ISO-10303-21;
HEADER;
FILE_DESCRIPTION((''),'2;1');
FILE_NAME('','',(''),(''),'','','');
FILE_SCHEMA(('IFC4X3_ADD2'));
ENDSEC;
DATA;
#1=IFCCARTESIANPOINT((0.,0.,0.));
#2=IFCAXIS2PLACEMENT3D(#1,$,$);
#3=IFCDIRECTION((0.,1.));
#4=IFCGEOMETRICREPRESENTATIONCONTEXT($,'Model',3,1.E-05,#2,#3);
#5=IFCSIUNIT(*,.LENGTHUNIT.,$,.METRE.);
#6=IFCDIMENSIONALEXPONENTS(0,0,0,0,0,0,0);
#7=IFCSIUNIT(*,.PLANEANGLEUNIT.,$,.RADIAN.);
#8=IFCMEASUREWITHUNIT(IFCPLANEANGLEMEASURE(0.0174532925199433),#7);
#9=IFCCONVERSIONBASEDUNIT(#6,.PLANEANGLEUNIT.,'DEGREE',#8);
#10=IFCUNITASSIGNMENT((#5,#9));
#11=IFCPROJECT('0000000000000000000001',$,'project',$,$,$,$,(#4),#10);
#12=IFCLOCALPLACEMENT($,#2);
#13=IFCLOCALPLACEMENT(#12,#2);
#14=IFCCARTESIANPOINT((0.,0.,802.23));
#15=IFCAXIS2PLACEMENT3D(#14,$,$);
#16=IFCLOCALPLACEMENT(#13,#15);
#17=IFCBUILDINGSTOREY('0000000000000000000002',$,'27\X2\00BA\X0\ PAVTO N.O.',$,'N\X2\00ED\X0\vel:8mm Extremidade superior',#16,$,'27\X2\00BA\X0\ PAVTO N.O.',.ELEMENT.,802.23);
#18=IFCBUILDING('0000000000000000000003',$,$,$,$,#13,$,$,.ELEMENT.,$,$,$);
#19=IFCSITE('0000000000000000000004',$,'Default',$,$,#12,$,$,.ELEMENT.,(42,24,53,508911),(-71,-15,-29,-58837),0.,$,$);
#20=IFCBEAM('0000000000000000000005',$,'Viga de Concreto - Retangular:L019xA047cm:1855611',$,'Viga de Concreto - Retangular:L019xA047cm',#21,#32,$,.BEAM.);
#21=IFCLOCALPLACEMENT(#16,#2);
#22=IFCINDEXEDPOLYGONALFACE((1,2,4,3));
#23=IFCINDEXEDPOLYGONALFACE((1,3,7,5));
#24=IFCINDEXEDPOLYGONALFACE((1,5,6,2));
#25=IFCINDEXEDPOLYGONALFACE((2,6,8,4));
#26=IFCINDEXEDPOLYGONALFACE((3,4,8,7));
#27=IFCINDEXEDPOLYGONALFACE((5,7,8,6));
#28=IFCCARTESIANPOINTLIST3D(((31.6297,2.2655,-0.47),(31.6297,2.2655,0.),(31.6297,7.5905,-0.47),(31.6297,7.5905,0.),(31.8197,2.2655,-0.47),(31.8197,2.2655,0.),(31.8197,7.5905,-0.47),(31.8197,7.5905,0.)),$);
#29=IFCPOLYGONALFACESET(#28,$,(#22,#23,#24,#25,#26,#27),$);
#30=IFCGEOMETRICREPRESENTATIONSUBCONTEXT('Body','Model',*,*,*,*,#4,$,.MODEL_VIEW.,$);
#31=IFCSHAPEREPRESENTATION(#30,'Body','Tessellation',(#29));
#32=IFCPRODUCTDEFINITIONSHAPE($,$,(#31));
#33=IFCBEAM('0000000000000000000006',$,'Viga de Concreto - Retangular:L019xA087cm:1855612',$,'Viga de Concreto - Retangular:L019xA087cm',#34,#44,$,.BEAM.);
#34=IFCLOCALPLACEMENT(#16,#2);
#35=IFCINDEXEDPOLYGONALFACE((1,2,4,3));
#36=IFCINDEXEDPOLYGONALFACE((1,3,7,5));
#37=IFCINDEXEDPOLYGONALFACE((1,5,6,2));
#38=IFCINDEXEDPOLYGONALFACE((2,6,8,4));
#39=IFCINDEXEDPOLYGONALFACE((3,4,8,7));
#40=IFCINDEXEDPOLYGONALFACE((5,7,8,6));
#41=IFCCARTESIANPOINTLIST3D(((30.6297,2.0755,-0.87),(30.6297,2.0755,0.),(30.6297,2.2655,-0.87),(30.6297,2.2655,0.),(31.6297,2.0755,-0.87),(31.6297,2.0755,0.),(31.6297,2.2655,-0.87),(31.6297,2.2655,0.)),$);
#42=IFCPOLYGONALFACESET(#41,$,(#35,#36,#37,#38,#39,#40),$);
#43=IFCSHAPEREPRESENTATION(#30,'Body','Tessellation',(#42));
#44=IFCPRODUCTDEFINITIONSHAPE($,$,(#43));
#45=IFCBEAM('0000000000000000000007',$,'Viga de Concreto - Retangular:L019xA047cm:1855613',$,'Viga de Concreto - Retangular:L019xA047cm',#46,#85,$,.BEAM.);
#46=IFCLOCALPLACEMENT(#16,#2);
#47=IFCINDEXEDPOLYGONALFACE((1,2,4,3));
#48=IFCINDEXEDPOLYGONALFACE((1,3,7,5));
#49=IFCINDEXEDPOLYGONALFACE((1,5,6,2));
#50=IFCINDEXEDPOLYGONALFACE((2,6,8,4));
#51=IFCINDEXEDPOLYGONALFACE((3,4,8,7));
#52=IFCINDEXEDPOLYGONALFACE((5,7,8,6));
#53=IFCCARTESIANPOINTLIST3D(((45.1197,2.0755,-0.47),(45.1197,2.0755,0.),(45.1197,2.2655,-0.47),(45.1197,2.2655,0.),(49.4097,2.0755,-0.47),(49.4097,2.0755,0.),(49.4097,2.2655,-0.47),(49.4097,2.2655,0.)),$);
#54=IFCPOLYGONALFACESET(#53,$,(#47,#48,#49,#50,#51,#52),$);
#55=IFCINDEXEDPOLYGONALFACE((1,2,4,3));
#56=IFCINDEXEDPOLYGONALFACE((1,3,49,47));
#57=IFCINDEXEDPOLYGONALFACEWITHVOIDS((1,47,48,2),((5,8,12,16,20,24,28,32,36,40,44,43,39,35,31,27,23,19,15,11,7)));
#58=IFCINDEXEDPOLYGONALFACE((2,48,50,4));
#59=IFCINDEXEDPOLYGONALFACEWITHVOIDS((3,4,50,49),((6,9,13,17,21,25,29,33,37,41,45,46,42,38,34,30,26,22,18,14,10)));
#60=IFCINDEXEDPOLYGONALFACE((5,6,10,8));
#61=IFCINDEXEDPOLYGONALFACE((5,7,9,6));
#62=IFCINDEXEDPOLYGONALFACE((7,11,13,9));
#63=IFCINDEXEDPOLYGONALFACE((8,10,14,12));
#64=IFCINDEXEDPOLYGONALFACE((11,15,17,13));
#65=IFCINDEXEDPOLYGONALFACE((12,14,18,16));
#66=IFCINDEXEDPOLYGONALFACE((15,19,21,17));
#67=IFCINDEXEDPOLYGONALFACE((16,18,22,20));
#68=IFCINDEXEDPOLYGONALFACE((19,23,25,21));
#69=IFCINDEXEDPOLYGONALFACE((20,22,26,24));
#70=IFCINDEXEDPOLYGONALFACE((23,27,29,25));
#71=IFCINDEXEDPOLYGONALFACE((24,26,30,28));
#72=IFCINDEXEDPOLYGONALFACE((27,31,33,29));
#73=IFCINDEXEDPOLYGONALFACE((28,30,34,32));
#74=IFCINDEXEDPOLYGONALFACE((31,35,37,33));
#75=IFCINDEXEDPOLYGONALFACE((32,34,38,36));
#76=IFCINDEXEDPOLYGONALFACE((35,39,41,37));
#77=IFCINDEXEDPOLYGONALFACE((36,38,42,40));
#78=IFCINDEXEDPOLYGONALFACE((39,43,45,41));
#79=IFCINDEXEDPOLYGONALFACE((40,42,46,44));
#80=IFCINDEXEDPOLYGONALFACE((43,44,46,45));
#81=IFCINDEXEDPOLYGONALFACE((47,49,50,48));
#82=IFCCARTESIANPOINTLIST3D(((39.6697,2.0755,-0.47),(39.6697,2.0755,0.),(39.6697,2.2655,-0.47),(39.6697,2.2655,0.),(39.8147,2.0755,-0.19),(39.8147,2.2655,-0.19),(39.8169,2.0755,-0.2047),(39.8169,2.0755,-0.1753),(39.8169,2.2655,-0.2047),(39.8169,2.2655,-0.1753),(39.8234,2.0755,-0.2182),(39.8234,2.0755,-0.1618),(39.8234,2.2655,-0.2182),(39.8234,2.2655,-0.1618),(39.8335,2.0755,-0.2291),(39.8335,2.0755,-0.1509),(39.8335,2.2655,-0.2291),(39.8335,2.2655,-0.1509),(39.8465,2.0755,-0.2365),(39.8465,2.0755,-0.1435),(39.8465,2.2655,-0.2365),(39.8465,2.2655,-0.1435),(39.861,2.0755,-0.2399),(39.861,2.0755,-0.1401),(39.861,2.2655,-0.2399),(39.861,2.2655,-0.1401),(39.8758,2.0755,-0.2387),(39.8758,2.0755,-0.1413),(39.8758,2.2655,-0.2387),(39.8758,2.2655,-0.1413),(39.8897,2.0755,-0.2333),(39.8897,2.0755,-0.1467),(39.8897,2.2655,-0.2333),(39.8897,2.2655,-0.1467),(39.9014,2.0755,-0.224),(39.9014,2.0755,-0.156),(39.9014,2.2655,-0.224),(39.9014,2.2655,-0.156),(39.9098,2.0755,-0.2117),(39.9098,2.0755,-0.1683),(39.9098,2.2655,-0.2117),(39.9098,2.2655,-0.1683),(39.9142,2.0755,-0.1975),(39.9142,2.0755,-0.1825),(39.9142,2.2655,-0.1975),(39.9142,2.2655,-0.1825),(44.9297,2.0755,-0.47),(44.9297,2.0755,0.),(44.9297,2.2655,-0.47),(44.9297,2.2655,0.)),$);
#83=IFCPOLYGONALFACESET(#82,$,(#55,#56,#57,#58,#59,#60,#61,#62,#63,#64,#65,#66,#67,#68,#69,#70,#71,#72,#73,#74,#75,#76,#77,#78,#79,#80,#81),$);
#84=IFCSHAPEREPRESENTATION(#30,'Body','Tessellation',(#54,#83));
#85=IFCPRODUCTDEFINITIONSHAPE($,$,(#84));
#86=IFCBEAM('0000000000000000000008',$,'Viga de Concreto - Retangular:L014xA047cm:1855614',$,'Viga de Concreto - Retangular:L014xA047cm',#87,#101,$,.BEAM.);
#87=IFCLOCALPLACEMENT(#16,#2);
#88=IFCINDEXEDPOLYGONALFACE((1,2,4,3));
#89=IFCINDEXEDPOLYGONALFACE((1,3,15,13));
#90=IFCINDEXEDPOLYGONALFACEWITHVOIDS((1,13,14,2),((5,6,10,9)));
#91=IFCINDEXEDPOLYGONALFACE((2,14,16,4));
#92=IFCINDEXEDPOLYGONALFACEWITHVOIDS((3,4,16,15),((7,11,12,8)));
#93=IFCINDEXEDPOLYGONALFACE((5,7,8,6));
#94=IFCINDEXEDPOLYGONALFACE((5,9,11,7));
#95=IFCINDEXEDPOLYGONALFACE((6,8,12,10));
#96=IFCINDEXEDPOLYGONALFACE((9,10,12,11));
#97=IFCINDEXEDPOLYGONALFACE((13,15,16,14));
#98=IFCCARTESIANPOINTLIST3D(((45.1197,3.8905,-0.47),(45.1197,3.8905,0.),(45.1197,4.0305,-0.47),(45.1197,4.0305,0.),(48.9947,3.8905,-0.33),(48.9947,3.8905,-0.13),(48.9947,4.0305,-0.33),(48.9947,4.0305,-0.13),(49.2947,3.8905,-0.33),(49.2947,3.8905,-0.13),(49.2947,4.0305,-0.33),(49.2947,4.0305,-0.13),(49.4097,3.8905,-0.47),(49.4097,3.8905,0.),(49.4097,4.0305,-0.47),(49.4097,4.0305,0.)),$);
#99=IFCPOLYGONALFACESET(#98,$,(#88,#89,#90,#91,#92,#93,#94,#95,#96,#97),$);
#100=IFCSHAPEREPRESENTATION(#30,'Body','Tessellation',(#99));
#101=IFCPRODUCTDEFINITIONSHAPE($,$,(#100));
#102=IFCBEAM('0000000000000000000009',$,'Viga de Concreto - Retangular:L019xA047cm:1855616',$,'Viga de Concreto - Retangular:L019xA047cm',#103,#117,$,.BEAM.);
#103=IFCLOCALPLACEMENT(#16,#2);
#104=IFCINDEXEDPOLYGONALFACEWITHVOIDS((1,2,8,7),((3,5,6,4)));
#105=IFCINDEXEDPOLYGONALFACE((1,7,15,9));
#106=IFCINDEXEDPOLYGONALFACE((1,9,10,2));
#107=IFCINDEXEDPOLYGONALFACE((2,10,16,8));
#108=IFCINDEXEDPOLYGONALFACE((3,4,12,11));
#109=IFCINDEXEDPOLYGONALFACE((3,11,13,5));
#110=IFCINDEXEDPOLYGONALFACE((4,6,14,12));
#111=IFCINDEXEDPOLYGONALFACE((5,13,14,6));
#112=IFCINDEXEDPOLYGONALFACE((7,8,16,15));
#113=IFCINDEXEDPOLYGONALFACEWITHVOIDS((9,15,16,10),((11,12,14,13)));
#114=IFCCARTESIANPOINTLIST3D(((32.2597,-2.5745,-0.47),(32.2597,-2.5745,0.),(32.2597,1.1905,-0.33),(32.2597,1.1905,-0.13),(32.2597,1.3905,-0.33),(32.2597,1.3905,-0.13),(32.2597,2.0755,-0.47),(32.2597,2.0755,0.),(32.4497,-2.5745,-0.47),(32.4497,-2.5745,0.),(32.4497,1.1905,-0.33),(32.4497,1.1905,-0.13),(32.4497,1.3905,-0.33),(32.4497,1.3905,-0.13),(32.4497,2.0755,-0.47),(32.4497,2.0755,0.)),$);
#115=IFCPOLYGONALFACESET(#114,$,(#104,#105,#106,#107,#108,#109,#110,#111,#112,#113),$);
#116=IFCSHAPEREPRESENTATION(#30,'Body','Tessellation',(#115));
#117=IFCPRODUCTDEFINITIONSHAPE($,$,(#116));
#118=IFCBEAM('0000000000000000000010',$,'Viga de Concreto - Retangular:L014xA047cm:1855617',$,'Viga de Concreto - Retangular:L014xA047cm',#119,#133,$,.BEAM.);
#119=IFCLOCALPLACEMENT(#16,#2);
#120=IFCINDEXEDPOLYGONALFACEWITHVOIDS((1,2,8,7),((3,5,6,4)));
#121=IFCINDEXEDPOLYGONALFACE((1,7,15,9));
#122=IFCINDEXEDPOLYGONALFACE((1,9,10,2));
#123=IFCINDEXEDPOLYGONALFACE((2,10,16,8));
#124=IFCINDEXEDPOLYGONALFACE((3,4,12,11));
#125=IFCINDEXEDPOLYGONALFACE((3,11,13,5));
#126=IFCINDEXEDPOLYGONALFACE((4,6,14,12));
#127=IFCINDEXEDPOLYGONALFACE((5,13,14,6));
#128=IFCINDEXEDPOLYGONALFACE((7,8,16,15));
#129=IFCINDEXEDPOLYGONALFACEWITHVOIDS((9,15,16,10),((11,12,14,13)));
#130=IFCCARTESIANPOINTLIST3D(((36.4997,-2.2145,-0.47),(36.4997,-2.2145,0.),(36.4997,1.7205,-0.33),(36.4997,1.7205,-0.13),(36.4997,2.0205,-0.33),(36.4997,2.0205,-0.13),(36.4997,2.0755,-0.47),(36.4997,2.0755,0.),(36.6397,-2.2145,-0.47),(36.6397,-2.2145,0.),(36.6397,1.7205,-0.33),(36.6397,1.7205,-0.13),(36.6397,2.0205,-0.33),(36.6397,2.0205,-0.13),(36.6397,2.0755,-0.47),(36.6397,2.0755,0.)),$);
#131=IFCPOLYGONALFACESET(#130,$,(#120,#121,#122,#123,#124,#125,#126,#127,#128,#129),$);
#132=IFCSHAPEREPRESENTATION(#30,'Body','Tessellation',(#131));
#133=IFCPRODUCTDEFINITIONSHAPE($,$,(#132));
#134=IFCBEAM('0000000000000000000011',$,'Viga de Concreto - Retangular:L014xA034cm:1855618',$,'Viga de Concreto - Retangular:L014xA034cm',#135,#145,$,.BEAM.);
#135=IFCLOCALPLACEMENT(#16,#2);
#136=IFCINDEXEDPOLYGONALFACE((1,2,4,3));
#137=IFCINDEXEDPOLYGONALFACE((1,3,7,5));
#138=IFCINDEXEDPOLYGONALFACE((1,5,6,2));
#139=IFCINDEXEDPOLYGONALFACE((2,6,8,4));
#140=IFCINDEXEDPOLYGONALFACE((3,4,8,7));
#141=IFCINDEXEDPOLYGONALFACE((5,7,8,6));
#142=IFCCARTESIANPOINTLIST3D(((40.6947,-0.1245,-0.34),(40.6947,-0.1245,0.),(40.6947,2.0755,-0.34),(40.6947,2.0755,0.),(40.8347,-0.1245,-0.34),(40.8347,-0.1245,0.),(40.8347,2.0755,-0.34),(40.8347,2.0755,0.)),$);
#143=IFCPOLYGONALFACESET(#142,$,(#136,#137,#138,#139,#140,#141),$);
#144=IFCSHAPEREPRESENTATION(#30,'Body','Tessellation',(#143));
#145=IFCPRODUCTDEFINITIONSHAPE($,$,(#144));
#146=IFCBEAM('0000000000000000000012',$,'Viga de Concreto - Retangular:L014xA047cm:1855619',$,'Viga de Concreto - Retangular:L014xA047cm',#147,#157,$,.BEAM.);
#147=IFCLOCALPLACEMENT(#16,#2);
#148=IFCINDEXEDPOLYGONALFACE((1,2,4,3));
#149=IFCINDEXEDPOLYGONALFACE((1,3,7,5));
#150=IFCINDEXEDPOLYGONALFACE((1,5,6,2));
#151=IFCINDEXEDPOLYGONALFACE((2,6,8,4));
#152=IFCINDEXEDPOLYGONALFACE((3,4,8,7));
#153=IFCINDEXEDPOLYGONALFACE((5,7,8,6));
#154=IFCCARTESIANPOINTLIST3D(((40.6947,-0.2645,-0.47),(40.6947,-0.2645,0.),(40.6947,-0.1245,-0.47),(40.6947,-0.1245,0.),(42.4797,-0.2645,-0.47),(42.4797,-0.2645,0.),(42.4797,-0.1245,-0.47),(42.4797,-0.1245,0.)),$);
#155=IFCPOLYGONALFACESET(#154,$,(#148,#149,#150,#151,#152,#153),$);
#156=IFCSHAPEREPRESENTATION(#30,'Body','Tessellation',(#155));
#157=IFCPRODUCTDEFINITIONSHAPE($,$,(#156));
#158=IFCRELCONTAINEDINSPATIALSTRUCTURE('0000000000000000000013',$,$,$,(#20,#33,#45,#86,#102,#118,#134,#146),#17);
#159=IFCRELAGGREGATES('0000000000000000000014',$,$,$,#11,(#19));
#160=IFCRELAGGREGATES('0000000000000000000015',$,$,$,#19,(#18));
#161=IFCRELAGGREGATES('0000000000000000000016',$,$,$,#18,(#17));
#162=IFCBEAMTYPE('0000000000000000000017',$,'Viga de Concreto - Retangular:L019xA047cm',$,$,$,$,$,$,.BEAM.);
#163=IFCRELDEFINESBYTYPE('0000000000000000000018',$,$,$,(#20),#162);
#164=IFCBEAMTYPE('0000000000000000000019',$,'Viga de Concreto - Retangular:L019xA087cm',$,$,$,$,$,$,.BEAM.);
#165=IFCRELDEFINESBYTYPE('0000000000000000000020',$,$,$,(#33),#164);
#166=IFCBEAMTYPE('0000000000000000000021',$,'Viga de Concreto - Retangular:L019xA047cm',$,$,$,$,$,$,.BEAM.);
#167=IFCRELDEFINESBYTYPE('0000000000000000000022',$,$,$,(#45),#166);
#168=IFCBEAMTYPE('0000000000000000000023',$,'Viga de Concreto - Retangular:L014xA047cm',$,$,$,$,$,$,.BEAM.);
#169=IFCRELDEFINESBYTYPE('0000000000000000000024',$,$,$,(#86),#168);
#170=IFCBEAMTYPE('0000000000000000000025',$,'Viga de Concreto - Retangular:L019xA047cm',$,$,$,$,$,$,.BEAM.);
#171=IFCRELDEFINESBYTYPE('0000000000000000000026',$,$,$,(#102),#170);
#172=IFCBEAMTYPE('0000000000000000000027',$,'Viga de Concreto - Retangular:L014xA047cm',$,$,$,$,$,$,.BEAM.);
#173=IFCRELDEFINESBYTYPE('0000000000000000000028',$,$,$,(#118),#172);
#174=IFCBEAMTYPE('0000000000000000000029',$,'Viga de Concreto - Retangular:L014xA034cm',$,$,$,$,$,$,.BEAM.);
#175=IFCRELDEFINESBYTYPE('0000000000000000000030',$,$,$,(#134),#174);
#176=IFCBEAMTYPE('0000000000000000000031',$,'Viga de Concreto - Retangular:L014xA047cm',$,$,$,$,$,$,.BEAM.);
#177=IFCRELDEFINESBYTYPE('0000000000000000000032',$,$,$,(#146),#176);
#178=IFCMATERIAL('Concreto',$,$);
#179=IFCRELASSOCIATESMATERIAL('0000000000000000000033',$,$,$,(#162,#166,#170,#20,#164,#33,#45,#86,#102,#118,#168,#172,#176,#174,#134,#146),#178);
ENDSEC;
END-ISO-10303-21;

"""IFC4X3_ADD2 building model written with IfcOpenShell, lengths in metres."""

from ifc_helpers import new_model, entity, si_unit, converted_unit, direction, frame, frame_2d, origin, origin_2d_with_axis, place, context, subcontext, project, spatial, rectangle, circle, extrude, boolean, source, transform, mapped, material, material_profile, profile_set, profile_usage, type_object, type_shapes, element, save


model = new_model("IFC4X3_ADD2")

# Units and contexts
model_context = context("Model", 3, precision=1e-05, world=origin(), true_north=direction((0.0, 1.0)))
body_context = subcontext(model_context, "Body", "Model", "MODEL_VIEW")
ifc_project = project(units=[si_unit("LENGTHUNIT", "METRE"), converted_unit("PLANEANGLEUNIT", "DEGREE", entity("IfcPlaneAngleMeasure", 0.0174532925199433), si_unit("PLANEANGLEUNIT", "RADIAN"), dimensions=[0, 0, 0, 0, 0, 0, 0])], contexts=[model_context])

# Site, building, storey
site_placement = place(None, origin())
site = spatial("IfcSite", under=ifc_project, at=site_placement, Name="Default", CompositionType="ELEMENT", RefLatitude=(42, 24, 53, 508911), RefLongitude=(-71, -15, -29, -58837), RefElevation=0.0)
building_placement = place(site_placement, origin())
building = spatial("IfcBuilding", under=site, at=building_placement, CompositionType="ELEMENT")
storey_placement = place(building_placement, frame((0.0, 0.0, 802.23)))
storey = spatial("IfcBuildingStorey", under=building, at=storey_placement, Name="27º PAVTO N.O.", ObjectType="Nível:8mm Extremidade superior", LongName="27º PAVTO N.O.", CompositionType="ELEMENT", Elevation=802.23)

# Beams
ifc_material = material(Name="Concreto")
ifc_material_profile_1 = material_profile(ifc_material, rectangle(XDim=0.47, YDim=0.19, at=frame_2d((0.0, 0.0), x_axis=(0.0, 1.0))), Name="L019xA047cm")
ifc_profile_set_1 = profile_set([ifc_material_profile_1], Name="L019xA047cm")
ifc_profile_usage_1 = profile_usage(ifc_profile_set_1, cardinal=8)
beam_type_1 = type_object("IfcBeamType", Name="Viga de Concreto - Retangular:L019xA047cm", PredefinedType="BEAM", material=ifc_profile_set_1)
shared_shape_1 = source(origin(), body_context, "Body", "SweptSolid", [
    extrude(rectangle(XDim=0.47, YDim=0.19, at=frame_2d((0.0, 0.0), x_axis=(0.0, 1.0))), frame((31.7247, 2.2655, 801.995), z_axis=(0.0, 1.0, 0.0), x_axis=(-1.0, 0.0, 0.0)), (0.0, 0.0, 1.0), 5.325),
])
type_shapes(beam_type_1, [shared_shape_1])
beam_1_placement = place(storey_placement, frame((0.0, 0.0, -802.23)))
element("IfcBeam", 1, at=beam_1_placement, inside=storey, type_object=beam_type_1, material=ifc_profile_usage_1, Name="Viga de Concreto - Retangular:L019xA047cm:1855611", ObjectType="Viga de Concreto - Retangular:L019xA047cm", PredefinedType="BEAM", context=body_context, shape_type="MappedRepresentation", body=[
    mapped(shared_shape_1, transform((0.0, 0.0, 0.0), scale=1.0)),
])
ifc_material_profile_2 = material_profile(ifc_material, rectangle(XDim=0.87, YDim=0.19, at=origin_2d_with_axis()), Name="L019xA087cm")
ifc_profile_set_2 = profile_set([ifc_material_profile_2], Name="L019xA087cm")
ifc_profile_usage_2 = profile_usage(ifc_profile_set_2, cardinal=8)
beam_type_2 = type_object("IfcBeamType", Name="Viga de Concreto - Retangular:L019xA087cm", PredefinedType="BEAM", material=ifc_profile_set_2)
shared_shape_2 = source(origin(), body_context, "Body", "SweptSolid", [
    extrude(rectangle(XDim=0.87, YDim=0.19, at=origin_2d_with_axis()), frame((31.6297, 2.1705, 801.795), z_axis=(-1.0, 0.0, 0.0), x_axis=(0.0, 0.0, -1.0)), (0.0, 0.0, 1.0), 1.0),
])
type_shapes(beam_type_2, [shared_shape_2])
beam_2_placement = place(storey_placement, frame((0.0, 0.0, -802.23)))
element("IfcBeam", 2, at=beam_2_placement, inside=storey, type_object=beam_type_2, material=ifc_profile_usage_2, Name="Viga de Concreto - Retangular:L019xA087cm:1855612", ObjectType="Viga de Concreto - Retangular:L019xA087cm", PredefinedType="BEAM", context=body_context, shape_type="MappedRepresentation", body=[
    mapped(shared_shape_2, transform((0.0, 0.0, 0.0), scale=1.0)),
])
beam_type_3 = type_object("IfcBeamType", Name="Viga de Concreto - Retangular:L019xA047cm", PredefinedType="BEAM", material=ifc_profile_set_1)
shared_shape_3 = source(origin(), body_context, "Body", "SweptSolid", [
    extrude(rectangle(XDim=0.47, YDim=0.19, at=origin_2d_with_axis()), frame((45.1197, 2.1705, 801.995), z_axis=(1.0, 0.0, 0.0), x_axis=(0.0, 0.0, -1.0)), (0.0, 0.0, 1.0), 4.29),
    boolean("DIFFERENCE", extrude(rectangle(XDim=0.47, YDim=0.19, at=frame_2d((0.0, 0.0), x_axis=(0.0, 1.0))), frame((39.6697, 2.1705, 801.995), z_axis=(1.0, 0.0, 0.0), x_axis=(0.0, 1.0, 0.0)), (0.0, 0.0, 1.0), 5.26), extrude(circle(Radius=0.05, at=origin_2d_with_axis()), frame((39.8647, 2.2655, 802.04), z_axis=(0.0, -1.0, 0.0), x_axis=(-1.0, 0.0, 0.0)), (0.0, 0.0, 1.0), 0.19)),
])
type_shapes(beam_type_3, [shared_shape_3])
beam_3_placement = place(storey_placement, frame((0.0, 0.0, -802.23)))
element("IfcBeam", 3, at=beam_3_placement, inside=storey, type_object=beam_type_3, material=ifc_material, Name="Viga de Concreto - Retangular:L019xA047cm:1855613", ObjectType="Viga de Concreto - Retangular:L019xA047cm", PredefinedType="BEAM", context=body_context, shape_type="MappedRepresentation", body=[
    mapped(shared_shape_3, transform((0.0, 0.0, 0.0), scale=1.0)),
])
ifc_material_profile_3 = material_profile(ifc_material, rectangle(XDim=0.47, YDim=0.14, at=frame_2d((0.0, 0.0), x_axis=(0.0, 1.0))), Name="L014xA047cm")
ifc_profile_set_3 = profile_set([ifc_material_profile_3], Name="L014xA047cm")
beam_type_4 = type_object("IfcBeamType", Name="Viga de Concreto - Retangular:L014xA047cm", PredefinedType="BEAM", material=ifc_profile_set_3)
shared_shape_4 = source(origin(), body_context, "Body", "CSG", [
    boolean("DIFFERENCE", extrude(rectangle(XDim=0.47, YDim=0.14, at=frame_2d((0.0, 0.0), x_axis=(0.0, 1.0))), frame((45.1197, 3.9605, 801.995), z_axis=(1.0, 0.0, 0.0), x_axis=(0.0, 1.0, 0.0)), (0.0, 0.0, 1.0), 4.29), extrude(rectangle(XDim=0.2, YDim=0.3, at=frame_2d((0.0, 0.0), x_axis=(0.0, 1.0))), frame((49.1447, 3.8905, 802.0), z_axis=(0.0, 1.0, 0.0), x_axis=(1.0, 0.0, 0.0)), (0.0, 0.0, 1.0), 0.14)),
])
type_shapes(beam_type_4, [shared_shape_4])
beam_4_placement = place(storey_placement, frame((0.0, 0.0, -802.23)))
element("IfcBeam", 4, at=beam_4_placement, inside=storey, type_object=beam_type_4, material=ifc_material, Name="Viga de Concreto - Retangular:L014xA047cm:1855614", ObjectType="Viga de Concreto - Retangular:L014xA047cm", PredefinedType="BEAM", context=body_context, shape_type="MappedRepresentation", body=[
    mapped(shared_shape_4, transform((0.0, 0.0, 0.0), scale=1.0)),
])
beam_type_5 = type_object("IfcBeamType", Name="Viga de Concreto - Retangular:L019xA047cm", PredefinedType="BEAM", material=ifc_profile_set_1)
shared_shape_5 = source(origin(), body_context, "Body", "CSG", [
    boolean("DIFFERENCE", extrude(rectangle(XDim=0.47, YDim=0.19, at=frame_2d((0.0, 0.0), x_axis=(0.0, 1.0))), frame((32.3547, 2.0755, 801.995), z_axis=(0.0, -1.0, 0.0), x_axis=(-1.0, 0.0, 0.0)), (0.0, 0.0, 1.0), 4.65), extrude(rectangle(XDim=0.2, YDim=0.2, at=frame_2d((0.0, 0.0), x_axis=(0.0, 1.0))), frame((32.2597, 1.2905, 802.0), z_axis=(1.0, 0.0, 0.0), x_axis=(0.0, -1.0, 0.0)), (0.0, 0.0, 1.0), 0.19)),
])
type_shapes(beam_type_5, [shared_shape_5])
beam_5_placement = place(storey_placement, frame((0.0, 0.0, -802.23)))
element("IfcBeam", 5, at=beam_5_placement, inside=storey, type_object=beam_type_5, material=ifc_material, Name="Viga de Concreto - Retangular:L019xA047cm:1855616", ObjectType="Viga de Concreto - Retangular:L019xA047cm", PredefinedType="BEAM", context=body_context, shape_type="MappedRepresentation", body=[
    mapped(shared_shape_5, transform((0.0, 0.0, 0.0), scale=1.0)),
])
beam_type_6 = type_object("IfcBeamType", Name="Viga de Concreto - Retangular:L014xA047cm", PredefinedType="BEAM", material=ifc_profile_set_3)
shared_shape_6 = source(origin(), body_context, "Body", "CSG", [
    boolean("DIFFERENCE", extrude(rectangle(XDim=0.47, YDim=0.14, at=frame_2d((0.0, 0.0), x_axis=(0.0, 1.0))), frame((36.5697, 2.0755, 801.995), z_axis=(0.0, -1.0, 0.0), x_axis=(-1.0, 0.0, 0.0)), (0.0, 0.0, 1.0), 4.29), extrude(rectangle(XDim=0.2, YDim=0.3, at=frame_2d((0.0, 0.0), x_axis=(0.0, 1.0))), frame((36.6397, 1.8705, 802.0), z_axis=(-1.0, 0.0, 0.0), x_axis=(0.0, 1.0, 0.0)), (0.0, 0.0, 1.0), 0.14)),
])
type_shapes(beam_type_6, [shared_shape_6])
beam_6_placement = place(storey_placement, frame((0.0, 0.0, -802.23)))
element("IfcBeam", 6, at=beam_6_placement, inside=storey, type_object=beam_type_6, material=ifc_material, Name="Viga de Concreto - Retangular:L014xA047cm:1855617", ObjectType="Viga de Concreto - Retangular:L014xA047cm", PredefinedType="BEAM", context=body_context, shape_type="MappedRepresentation", body=[
    mapped(shared_shape_6, transform((0.0, 0.0, 0.0), scale=1.0)),
])
ifc_material_profile_4 = material_profile(ifc_material, rectangle(XDim=0.34, YDim=0.14, at=frame_2d((0.0, 0.0), x_axis=(0.0, 1.0))), Name="L014xA034cm")
ifc_profile_set_4 = profile_set([ifc_material_profile_4], Name="L014xA034cm")
ifc_profile_usage_3 = profile_usage(ifc_profile_set_4, cardinal=8)
beam_type_7 = type_object("IfcBeamType", Name="Viga de Concreto - Retangular:L014xA034cm", PredefinedType="BEAM", material=ifc_profile_set_4)
shared_shape_7 = source(origin(), body_context, "Body", "SweptSolid", [
    extrude(rectangle(XDim=0.34, YDim=0.14, at=frame_2d((0.0, 0.0), x_axis=(0.0, 1.0))), frame((40.7647, 2.0755, 802.06), z_axis=(0.0, -1.0, 0.0), x_axis=(-1.0, 0.0, 0.0)), (0.0, 0.0, 1.0), 2.2),
])
type_shapes(beam_type_7, [shared_shape_7])
beam_7_placement = place(storey_placement, frame((0.0, 0.0, -802.23)))
element("IfcBeam", 7, at=beam_7_placement, inside=storey, type_object=beam_type_7, material=ifc_profile_usage_3, Name="Viga de Concreto - Retangular:L014xA034cm:1855618", ObjectType="Viga de Concreto - Retangular:L014xA034cm", PredefinedType="BEAM", context=body_context, shape_type="MappedRepresentation", body=[
    mapped(shared_shape_7, transform((0.0, 0.0, 0.0), scale=1.0)),
])
ifc_profile_usage_4 = profile_usage(ifc_profile_set_3, cardinal=8)
beam_type_8 = type_object("IfcBeamType", Name="Viga de Concreto - Retangular:L014xA047cm", PredefinedType="BEAM", material=ifc_profile_set_3)
shared_shape_8 = source(origin(), body_context, "Body", "SweptSolid", [
    extrude(rectangle(XDim=0.47, YDim=0.14, at=origin_2d_with_axis()), frame((42.4797, -0.1945, 801.995), z_axis=(-1.0, 0.0, 0.0), x_axis=(0.0, 0.0, -1.0)), (0.0, 0.0, 1.0), 1.785),
])
type_shapes(beam_type_8, [shared_shape_8])
beam_8_placement = place(storey_placement, frame((0.0, 0.0, -802.23)))
element("IfcBeam", 8, at=beam_8_placement, inside=storey, type_object=beam_type_8, material=ifc_profile_usage_4, Name="Viga de Concreto - Retangular:L014xA047cm:1855619", ObjectType="Viga de Concreto - Retangular:L014xA047cm", PredefinedType="BEAM", context=body_context, shape_type="MappedRepresentation", body=[
    mapped(shared_shape_8, transform((0.0, 0.0, 0.0), scale=1.0)),
])

save(model, "model.ifc")
